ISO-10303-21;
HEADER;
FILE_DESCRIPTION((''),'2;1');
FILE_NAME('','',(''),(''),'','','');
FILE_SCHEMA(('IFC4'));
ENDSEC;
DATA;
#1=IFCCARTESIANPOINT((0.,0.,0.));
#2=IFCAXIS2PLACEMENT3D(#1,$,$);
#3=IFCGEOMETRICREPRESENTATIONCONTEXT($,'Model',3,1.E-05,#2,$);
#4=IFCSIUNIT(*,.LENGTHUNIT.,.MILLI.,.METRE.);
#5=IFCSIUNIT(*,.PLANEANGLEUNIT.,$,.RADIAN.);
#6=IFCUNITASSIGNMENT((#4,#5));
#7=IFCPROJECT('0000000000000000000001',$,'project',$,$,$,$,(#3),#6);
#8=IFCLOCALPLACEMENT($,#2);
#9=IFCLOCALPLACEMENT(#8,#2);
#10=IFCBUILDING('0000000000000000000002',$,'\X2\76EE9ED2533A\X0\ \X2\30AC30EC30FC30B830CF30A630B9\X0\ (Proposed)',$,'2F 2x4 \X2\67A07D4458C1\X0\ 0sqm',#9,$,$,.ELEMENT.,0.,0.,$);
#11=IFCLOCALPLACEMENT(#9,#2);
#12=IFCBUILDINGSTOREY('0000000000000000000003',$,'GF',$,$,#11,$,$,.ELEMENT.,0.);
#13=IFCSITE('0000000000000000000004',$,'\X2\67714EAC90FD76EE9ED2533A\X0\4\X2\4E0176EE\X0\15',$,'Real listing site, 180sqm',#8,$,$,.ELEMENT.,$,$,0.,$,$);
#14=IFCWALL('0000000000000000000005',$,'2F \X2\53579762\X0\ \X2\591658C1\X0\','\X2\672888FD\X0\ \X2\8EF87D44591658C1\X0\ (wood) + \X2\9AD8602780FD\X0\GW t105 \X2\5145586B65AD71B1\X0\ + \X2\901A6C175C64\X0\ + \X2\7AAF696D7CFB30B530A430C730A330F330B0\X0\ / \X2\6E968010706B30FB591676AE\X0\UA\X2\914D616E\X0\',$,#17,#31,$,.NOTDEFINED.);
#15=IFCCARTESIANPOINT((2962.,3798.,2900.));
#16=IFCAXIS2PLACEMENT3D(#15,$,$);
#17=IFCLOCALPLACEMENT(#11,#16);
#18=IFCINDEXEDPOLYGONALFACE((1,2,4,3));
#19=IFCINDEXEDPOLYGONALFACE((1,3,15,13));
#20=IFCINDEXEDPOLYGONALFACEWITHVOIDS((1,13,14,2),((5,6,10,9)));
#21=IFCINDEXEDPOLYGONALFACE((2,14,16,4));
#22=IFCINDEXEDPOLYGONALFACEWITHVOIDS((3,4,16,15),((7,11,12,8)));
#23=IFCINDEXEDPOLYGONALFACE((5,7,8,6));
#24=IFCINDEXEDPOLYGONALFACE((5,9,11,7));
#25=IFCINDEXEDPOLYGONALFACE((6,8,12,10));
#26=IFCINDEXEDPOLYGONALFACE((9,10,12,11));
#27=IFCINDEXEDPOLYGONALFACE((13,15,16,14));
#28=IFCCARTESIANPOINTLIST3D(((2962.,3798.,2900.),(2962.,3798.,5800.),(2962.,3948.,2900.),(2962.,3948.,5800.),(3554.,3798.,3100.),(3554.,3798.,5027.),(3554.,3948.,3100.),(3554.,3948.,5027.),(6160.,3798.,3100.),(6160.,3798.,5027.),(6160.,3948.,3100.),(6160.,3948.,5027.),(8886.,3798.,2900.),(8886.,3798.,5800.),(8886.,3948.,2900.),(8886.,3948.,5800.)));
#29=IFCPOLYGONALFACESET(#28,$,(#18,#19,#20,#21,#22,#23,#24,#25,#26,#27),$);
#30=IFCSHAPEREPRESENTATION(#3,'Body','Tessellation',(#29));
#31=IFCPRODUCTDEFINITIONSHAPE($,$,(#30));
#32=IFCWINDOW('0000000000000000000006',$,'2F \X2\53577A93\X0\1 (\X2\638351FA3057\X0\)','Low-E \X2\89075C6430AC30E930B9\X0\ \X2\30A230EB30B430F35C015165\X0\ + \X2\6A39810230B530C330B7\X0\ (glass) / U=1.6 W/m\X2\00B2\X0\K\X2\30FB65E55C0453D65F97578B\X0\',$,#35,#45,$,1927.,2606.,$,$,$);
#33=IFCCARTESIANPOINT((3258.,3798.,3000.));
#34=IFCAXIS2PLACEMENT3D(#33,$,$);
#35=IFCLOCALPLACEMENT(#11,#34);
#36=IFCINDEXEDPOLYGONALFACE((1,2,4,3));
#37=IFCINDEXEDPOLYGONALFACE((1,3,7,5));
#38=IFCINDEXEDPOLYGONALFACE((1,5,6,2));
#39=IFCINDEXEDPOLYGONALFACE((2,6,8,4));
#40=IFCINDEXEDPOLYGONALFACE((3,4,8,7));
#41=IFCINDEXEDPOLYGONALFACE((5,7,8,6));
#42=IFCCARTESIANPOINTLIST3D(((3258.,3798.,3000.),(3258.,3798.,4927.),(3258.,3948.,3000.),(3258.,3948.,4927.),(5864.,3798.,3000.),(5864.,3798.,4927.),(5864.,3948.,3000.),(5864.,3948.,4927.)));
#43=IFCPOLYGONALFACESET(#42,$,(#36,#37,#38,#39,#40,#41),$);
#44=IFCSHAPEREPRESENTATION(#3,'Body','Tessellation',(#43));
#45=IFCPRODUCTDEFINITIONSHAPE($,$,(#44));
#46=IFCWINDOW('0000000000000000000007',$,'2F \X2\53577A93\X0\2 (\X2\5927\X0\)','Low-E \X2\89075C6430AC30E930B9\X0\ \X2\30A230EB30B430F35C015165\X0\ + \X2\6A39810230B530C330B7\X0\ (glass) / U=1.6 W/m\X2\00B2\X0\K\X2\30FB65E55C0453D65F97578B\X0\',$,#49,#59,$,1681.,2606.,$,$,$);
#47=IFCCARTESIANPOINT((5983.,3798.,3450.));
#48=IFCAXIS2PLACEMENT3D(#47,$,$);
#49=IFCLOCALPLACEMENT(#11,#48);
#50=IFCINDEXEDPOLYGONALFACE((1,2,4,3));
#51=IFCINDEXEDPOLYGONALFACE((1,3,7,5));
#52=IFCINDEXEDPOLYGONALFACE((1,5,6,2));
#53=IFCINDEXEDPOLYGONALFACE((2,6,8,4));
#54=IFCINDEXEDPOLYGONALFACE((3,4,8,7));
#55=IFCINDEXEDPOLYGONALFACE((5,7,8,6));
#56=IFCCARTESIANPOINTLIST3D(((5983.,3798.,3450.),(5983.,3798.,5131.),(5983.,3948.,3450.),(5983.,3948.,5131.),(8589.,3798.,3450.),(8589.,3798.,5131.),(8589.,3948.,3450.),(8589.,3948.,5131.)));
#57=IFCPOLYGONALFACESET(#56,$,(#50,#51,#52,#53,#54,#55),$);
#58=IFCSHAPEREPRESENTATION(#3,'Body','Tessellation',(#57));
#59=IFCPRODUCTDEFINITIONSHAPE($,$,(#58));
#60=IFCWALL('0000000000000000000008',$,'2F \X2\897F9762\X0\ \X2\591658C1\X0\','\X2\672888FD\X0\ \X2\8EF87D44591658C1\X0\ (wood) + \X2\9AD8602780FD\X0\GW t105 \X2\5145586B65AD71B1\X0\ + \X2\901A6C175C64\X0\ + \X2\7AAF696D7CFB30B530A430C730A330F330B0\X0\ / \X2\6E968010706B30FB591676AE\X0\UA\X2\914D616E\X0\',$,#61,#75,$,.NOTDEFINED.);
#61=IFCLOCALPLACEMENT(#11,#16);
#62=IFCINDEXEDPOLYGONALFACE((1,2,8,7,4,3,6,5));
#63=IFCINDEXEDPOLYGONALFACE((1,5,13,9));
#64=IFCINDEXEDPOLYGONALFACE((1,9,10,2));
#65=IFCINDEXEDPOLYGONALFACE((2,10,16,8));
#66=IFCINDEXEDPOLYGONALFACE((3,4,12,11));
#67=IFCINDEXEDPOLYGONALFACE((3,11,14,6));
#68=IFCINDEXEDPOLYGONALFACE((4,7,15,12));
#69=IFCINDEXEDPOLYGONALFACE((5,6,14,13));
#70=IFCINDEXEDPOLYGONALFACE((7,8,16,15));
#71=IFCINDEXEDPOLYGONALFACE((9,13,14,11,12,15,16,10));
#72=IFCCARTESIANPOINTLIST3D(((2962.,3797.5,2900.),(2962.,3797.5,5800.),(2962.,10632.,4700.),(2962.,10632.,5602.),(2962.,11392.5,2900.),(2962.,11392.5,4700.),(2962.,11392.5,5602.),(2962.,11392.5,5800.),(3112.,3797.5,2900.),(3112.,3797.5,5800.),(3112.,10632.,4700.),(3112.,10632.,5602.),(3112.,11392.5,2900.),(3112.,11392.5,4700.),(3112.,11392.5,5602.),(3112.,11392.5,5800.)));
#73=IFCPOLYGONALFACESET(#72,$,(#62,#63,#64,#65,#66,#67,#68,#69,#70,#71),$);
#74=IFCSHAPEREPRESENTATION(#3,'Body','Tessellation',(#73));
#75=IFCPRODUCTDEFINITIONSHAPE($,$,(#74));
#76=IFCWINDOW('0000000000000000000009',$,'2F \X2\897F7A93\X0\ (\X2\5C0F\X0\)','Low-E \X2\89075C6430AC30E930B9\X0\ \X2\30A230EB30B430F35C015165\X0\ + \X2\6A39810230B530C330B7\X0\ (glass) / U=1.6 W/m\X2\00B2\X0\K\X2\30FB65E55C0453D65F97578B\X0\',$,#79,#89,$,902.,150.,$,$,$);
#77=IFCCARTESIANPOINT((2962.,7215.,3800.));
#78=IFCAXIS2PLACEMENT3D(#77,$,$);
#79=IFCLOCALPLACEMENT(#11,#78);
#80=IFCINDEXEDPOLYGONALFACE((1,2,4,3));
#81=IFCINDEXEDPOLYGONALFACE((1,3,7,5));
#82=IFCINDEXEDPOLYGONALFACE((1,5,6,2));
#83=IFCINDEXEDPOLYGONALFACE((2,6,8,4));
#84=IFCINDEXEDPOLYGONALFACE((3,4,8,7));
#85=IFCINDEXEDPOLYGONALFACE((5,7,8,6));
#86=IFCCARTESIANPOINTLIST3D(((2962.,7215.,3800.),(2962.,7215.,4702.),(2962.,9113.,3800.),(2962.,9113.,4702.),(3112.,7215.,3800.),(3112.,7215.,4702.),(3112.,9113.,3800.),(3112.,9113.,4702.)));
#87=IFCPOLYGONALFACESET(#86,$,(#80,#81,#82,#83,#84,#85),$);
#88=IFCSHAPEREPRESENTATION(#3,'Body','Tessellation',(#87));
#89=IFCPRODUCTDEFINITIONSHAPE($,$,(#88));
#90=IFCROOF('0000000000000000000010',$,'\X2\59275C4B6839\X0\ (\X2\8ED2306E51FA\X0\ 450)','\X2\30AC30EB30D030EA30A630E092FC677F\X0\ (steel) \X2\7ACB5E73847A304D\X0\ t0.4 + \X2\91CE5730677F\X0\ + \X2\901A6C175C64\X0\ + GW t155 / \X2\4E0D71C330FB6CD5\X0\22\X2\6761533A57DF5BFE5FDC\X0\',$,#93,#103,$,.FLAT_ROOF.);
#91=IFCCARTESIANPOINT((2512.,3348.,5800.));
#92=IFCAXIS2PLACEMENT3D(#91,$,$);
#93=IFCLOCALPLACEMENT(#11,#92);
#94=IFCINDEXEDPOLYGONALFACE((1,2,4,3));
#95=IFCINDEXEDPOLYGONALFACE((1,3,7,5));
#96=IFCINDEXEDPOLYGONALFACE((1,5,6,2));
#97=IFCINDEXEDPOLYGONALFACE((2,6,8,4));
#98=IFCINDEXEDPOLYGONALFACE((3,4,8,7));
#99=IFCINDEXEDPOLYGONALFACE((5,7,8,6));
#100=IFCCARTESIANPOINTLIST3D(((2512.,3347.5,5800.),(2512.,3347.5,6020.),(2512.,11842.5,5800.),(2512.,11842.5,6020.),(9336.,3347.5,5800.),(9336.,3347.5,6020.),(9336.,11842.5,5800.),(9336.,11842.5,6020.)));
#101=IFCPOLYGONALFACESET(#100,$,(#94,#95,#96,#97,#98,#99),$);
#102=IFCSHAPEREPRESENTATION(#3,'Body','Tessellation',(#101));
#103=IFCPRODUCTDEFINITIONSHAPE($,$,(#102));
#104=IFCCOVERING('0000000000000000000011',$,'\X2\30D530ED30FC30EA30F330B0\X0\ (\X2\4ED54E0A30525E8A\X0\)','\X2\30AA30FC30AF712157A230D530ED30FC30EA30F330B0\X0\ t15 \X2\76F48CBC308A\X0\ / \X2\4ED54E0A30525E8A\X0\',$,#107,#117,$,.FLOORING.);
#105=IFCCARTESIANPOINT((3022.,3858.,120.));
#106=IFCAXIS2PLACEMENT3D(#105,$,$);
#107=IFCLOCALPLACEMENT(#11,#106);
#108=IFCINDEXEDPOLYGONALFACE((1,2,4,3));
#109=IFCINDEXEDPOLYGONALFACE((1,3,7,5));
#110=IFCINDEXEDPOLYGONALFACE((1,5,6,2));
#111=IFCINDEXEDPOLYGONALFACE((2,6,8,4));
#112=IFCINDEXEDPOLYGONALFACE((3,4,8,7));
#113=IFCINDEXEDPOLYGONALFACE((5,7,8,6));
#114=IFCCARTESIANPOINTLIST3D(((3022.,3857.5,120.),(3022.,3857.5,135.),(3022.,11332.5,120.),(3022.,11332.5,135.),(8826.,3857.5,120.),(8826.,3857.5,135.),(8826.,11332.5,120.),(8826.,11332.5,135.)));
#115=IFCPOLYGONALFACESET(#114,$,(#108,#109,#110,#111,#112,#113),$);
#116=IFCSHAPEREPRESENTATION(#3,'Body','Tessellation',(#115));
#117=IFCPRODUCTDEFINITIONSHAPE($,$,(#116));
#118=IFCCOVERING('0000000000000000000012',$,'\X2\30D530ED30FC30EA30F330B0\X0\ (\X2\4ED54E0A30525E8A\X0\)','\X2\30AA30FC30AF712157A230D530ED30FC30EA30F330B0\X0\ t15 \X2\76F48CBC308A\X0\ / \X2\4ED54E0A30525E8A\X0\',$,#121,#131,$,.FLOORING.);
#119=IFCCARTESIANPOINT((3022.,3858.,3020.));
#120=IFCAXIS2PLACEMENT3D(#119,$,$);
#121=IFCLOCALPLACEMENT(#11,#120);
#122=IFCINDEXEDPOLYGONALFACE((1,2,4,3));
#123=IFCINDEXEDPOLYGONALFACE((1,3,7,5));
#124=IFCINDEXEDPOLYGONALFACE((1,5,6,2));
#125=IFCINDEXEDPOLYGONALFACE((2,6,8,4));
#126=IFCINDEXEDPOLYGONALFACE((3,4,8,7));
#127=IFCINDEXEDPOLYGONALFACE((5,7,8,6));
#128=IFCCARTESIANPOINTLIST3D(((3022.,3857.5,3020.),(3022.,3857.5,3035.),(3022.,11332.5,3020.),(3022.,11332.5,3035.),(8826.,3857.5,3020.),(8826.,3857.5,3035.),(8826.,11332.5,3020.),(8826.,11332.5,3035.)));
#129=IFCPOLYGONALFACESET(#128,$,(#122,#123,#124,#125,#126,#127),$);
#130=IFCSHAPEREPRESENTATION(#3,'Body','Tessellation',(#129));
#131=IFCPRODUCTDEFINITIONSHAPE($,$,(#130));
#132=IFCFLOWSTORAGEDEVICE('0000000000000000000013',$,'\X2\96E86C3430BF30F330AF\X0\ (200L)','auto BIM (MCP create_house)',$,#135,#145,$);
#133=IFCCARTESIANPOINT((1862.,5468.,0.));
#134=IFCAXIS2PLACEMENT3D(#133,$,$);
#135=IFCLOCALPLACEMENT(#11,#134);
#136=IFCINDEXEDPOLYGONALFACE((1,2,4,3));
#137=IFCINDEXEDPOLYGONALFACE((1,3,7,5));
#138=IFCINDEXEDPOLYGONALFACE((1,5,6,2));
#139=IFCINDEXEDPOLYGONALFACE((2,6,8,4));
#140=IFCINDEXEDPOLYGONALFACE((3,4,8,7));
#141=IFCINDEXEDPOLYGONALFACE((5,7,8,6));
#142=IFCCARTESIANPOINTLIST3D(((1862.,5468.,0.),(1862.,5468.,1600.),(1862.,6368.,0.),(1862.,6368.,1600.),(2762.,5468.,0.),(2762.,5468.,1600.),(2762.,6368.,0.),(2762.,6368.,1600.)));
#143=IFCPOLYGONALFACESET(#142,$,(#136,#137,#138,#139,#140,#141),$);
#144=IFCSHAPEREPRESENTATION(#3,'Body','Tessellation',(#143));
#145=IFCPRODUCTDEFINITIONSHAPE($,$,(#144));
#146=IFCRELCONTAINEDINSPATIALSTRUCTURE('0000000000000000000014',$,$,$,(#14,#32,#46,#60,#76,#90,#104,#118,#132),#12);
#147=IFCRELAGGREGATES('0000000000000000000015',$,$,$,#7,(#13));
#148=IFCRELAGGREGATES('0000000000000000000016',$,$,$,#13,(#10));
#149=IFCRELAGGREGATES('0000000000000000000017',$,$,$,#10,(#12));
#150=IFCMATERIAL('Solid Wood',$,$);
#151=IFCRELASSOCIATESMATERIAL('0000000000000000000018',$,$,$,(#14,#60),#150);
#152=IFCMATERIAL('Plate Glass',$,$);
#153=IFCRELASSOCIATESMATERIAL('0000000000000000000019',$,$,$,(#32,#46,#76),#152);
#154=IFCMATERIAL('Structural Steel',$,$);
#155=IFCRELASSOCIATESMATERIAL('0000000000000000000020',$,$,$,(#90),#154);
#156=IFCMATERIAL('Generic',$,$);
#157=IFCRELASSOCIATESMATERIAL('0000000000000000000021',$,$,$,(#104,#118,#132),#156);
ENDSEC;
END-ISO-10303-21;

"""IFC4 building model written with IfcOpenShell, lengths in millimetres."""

from ifc_helpers import new_model, si_unit, frame, frame_2d, origin, place, context, project, spatial, rectangle, extrude, material, element, fill, save


model = new_model("IFC4")

# Units and contexts
model_context = context("Model", 3, precision=1e-05, world=origin())
ifc_project = project(units=[si_unit("LENGTHUNIT", "METRE", prefix="MILLI"), si_unit("PLANEANGLEUNIT", "RADIAN")], contexts=[model_context])

# Site, building, storey
site_placement = place(None, origin())
site = spatial("IfcSite", under=ifc_project, at=site_placement, Name="東京都目黒区4丁目15", ObjectType="Real listing site, 180sqm", CompositionType="ELEMENT", RefElevation=0.0)
building_placement = place(site_placement, origin())
building = spatial("IfcBuilding", under=site, at=building_placement, Name="目黒区 ガレージハウス (Proposed)", ObjectType="2F 2x4 枠組壁 0sqm", CompositionType="ELEMENT", ElevationOfRefHeight=0.0, ElevationOfTerrain=0.0)
storey_placement = place(building_placement, origin())
storey = spatial("IfcBuildingStorey", under=building, at=storey_placement, Name="GF", CompositionType="ELEMENT", Elevation=0.0)

# Shared definitions
ifc_material_1 = material(Name="Solid Wood")

# Shared definitions
ifc_material_2 = material(Name="Plate Glass")

# Wall, openings, windows
wall_1_placement = place(storey_placement, frame((2962.0, 3798.0, 2900.0)))
wall_1 = element("IfcWall", 1, at=wall_1_placement, inside=storey, material=ifc_material_1, Name="2F 南面 外壁", Description="木製 軸組外壁 (wood) + 高性能GW t105 充填断熱 + 通気層 + 窯業系サイディング / 準耐火・外皮UA配慮", PredefinedType="NOTDEFINED", context=model_context, shape_type="SweptSolid", body=[
    extrude(rectangle(XDim=5924.0, YDim=150.0, at=frame_2d((2962.0, 75.0))), frame((2962.0, 3798.0, 2900.0)), (0.0, 0.0, 1.0), 2900.0),
])
opening_1_placement = place(storey_placement, frame((3258.0, 3798.0, 3000.0)))
opening_1 = element("IfcOpeningElement", 2, at=opening_1_placement, cuts=wall_1, PredefinedType="NOTDEFINED", context=model_context, shape_type="SweptSolid", body=[
    extrude(rectangle(XDim=2606.0, YDim=150.0, at=frame_2d((1303.0, 75.0))), frame((3258.0, 3798.0, 3000.0)), (0.0, 0.0, 1.0), 1927.0),
])
opening_2_placement = place(storey_placement, frame((5983.0, 3798.0, 3450.0)))
opening_2 = element("IfcOpeningElement", 3, at=opening_2_placement, cuts=wall_1, PredefinedType="NOTDEFINED", context=model_context, shape_type="SweptSolid", body=[
    extrude(rectangle(XDim=2606.0, YDim=150.0, at=frame_2d((1303.0, 75.0))), frame((5983.0, 3798.0, 3450.0)), (0.0, 0.0, 1.0), 1681.0),
])
window_1_placement = place(storey_placement, frame((3258.0, 3798.0, 3000.0)))
window_1 = element("IfcWindow", 4, at=window_1_placement, inside=storey, material=ifc_material_2, Name="2F 南窓1 (掃出し)", Description="Low-E 複層ガラス アルゴン封入 + 樹脂サッシ (glass) / U=1.6 W/m²K・日射取得型", OverallHeight=1927.0, OverallWidth=2606.0, context=model_context, shape_type="SweptSolid", body=[
    extrude(rectangle(XDim=2606.0, YDim=150.0, at=frame_2d((1303.0, 75.0))), frame((3258.0, 3798.0, 3000.0)), (0.0, 0.0, 1.0), 1927.0),
])
fill(opening_1, window_1)
window_2_placement = place(storey_placement, frame((5983.0, 3798.0, 3450.0)))
window_2 = element("IfcWindow", 5, at=window_2_placement, inside=storey, material=ifc_material_2, Name="2F 南窓2 (大)", Description="Low-E 複層ガラス アルゴン封入 + 樹脂サッシ (glass) / U=1.6 W/m²K・日射取得型", OverallHeight=1681.0, OverallWidth=2606.0, context=model_context, shape_type="SweptSolid", body=[
    extrude(rectangle(XDim=2606.0, YDim=150.0, at=frame_2d((1303.0, 75.0))), frame((5983.0, 3798.0, 3450.0)), (0.0, 0.0, 1.0), 1681.0),
])
fill(opening_2, window_2)

# Wall, opening, window
wall_2_placement = place(storey_placement, frame((2962.0, 3798.0, 2900.0)))
wall_2 = element("IfcWall", 6, at=wall_2_placement, inside=storey, material=ifc_material_1, Name="2F 西面 外壁", Description="木製 軸組外壁 (wood) + 高性能GW t105 充填断熱 + 通気層 + 窯業系サイディング / 準耐火・外皮UA配慮", PredefinedType="NOTDEFINED", context=model_context, shape_type="SweptSolid", body=[
    extrude(rectangle(XDim=150.0, YDim=7595.0, at=frame_2d((75.0, 3797.0))), frame((2962.0, 3798.0, 2900.0)), (0.0, 0.0, 1.0), 2900.0),
])
opening_3_placement = place(storey_placement, frame((2962.0, 7215.0, 3800.0)))
opening_3 = element("IfcOpeningElement", 7, at=opening_3_placement, cuts=wall_2, PredefinedType="NOTDEFINED", context=model_context, shape_type="SweptSolid", body=[
    extrude(rectangle(XDim=150.0, YDim=1898.0, at=frame_2d((75.0, 949.0))), frame((2962.0, 7215.0, 3800.0)), (0.0, 0.0, 1.0), 902.0),
])
window_3_placement = place(storey_placement, frame((2962.0, 7215.0, 3800.0)))
window_3 = element("IfcWindow", 8, at=window_3_placement, inside=storey, material=ifc_material_2, Name="2F 西窓 (小)", Description="Low-E 複層ガラス アルゴン封入 + 樹脂サッシ (glass) / U=1.6 W/m²K・日射取得型", OverallHeight=902.0, OverallWidth=150.0, context=model_context, shape_type="SweptSolid", body=[
    extrude(rectangle(XDim=150.0, YDim=1898.0, at=frame_2d((75.0, 949.0))), frame((2962.0, 7215.0, 3800.0)), (0.0, 0.0, 1.0), 902.0),
])
fill(opening_3, window_3)

# Roof
ifc_material_3 = material(Name="Structural Steel")
roof_placement = place(storey_placement, frame((2512.0, 3348.0, 5800.0)))
element("IfcRoof", 9, at=roof_placement, inside=storey, material=ifc_material_3, Name="大屋根 (軒の出 450)", Description="ガルバリウム鋼板 (steel) 立平葺き t0.4 + 野地板 + 通気層 + GW t155 / 不燃・法22条区域対応", PredefinedType="FLAT_ROOF", context=model_context, shape_type="SweptSolid", body=[
    extrude(rectangle(XDim=6824.0, YDim=8495.0, at=frame_2d((3412.0, 4247.0))), frame((2512.0, 3348.0, 5800.0)), (0.0, 0.0, 1.0), 220.0),
])

# Coverings
ifc_material_4 = material(Name="Generic")
covering_1_placement = place(storey_placement, frame((3022.0, 3858.0, 120.0)))
element("IfcCovering", 10, at=covering_1_placement, inside=storey, material=ifc_material_4, Name="フローリング (仕上げ床)", Description="オーク無垢フローリング t15 直貼り / 仕上げ床", PredefinedType="FLOORING", context=model_context, shape_type="SweptSolid", body=[
    extrude(rectangle(XDim=5804.0, YDim=7475.0, at=frame_2d((2902.0, 3737.0))), frame((3022.0, 3858.0, 120.0)), (0.0, 0.0, 1.0), 15.0),
])
covering_2_placement = place(storey_placement, frame((3022.0, 3858.0, 3020.0)))
element("IfcCovering", 11, at=covering_2_placement, inside=storey, material=ifc_material_4, Name="フローリング (仕上げ床)", Description="オーク無垢フローリング t15 直貼り / 仕上げ床", PredefinedType="FLOORING", context=model_context, shape_type="SweptSolid", body=[
    extrude(rectangle(XDim=5804.0, YDim=7475.0, at=frame_2d((2902.0, 3737.0))), frame((3022.0, 3858.0, 3020.0)), (0.0, 0.0, 1.0), 15.0),
])

# Flow storage device
flow_storage_device_placement = place(storey_placement, frame((1862.0, 5468.0, 0.0)))
element("IfcFlowStorageDevice", 12, at=flow_storage_device_placement, inside=storey, material=ifc_material_4, Name="雨水タンク (200L)", Description="auto BIM (MCP create_house)", context=model_context, shape_type="SweptSolid", body=[
    extrude(rectangle(XDim=900.0, YDim=900.0, at=frame_2d((450.0, 450.0))), frame((1862.0, 5468.0, 0.0)), (0.0, 0.0, 1.0), 1600.0),
])

save(model, "model.ifc")
